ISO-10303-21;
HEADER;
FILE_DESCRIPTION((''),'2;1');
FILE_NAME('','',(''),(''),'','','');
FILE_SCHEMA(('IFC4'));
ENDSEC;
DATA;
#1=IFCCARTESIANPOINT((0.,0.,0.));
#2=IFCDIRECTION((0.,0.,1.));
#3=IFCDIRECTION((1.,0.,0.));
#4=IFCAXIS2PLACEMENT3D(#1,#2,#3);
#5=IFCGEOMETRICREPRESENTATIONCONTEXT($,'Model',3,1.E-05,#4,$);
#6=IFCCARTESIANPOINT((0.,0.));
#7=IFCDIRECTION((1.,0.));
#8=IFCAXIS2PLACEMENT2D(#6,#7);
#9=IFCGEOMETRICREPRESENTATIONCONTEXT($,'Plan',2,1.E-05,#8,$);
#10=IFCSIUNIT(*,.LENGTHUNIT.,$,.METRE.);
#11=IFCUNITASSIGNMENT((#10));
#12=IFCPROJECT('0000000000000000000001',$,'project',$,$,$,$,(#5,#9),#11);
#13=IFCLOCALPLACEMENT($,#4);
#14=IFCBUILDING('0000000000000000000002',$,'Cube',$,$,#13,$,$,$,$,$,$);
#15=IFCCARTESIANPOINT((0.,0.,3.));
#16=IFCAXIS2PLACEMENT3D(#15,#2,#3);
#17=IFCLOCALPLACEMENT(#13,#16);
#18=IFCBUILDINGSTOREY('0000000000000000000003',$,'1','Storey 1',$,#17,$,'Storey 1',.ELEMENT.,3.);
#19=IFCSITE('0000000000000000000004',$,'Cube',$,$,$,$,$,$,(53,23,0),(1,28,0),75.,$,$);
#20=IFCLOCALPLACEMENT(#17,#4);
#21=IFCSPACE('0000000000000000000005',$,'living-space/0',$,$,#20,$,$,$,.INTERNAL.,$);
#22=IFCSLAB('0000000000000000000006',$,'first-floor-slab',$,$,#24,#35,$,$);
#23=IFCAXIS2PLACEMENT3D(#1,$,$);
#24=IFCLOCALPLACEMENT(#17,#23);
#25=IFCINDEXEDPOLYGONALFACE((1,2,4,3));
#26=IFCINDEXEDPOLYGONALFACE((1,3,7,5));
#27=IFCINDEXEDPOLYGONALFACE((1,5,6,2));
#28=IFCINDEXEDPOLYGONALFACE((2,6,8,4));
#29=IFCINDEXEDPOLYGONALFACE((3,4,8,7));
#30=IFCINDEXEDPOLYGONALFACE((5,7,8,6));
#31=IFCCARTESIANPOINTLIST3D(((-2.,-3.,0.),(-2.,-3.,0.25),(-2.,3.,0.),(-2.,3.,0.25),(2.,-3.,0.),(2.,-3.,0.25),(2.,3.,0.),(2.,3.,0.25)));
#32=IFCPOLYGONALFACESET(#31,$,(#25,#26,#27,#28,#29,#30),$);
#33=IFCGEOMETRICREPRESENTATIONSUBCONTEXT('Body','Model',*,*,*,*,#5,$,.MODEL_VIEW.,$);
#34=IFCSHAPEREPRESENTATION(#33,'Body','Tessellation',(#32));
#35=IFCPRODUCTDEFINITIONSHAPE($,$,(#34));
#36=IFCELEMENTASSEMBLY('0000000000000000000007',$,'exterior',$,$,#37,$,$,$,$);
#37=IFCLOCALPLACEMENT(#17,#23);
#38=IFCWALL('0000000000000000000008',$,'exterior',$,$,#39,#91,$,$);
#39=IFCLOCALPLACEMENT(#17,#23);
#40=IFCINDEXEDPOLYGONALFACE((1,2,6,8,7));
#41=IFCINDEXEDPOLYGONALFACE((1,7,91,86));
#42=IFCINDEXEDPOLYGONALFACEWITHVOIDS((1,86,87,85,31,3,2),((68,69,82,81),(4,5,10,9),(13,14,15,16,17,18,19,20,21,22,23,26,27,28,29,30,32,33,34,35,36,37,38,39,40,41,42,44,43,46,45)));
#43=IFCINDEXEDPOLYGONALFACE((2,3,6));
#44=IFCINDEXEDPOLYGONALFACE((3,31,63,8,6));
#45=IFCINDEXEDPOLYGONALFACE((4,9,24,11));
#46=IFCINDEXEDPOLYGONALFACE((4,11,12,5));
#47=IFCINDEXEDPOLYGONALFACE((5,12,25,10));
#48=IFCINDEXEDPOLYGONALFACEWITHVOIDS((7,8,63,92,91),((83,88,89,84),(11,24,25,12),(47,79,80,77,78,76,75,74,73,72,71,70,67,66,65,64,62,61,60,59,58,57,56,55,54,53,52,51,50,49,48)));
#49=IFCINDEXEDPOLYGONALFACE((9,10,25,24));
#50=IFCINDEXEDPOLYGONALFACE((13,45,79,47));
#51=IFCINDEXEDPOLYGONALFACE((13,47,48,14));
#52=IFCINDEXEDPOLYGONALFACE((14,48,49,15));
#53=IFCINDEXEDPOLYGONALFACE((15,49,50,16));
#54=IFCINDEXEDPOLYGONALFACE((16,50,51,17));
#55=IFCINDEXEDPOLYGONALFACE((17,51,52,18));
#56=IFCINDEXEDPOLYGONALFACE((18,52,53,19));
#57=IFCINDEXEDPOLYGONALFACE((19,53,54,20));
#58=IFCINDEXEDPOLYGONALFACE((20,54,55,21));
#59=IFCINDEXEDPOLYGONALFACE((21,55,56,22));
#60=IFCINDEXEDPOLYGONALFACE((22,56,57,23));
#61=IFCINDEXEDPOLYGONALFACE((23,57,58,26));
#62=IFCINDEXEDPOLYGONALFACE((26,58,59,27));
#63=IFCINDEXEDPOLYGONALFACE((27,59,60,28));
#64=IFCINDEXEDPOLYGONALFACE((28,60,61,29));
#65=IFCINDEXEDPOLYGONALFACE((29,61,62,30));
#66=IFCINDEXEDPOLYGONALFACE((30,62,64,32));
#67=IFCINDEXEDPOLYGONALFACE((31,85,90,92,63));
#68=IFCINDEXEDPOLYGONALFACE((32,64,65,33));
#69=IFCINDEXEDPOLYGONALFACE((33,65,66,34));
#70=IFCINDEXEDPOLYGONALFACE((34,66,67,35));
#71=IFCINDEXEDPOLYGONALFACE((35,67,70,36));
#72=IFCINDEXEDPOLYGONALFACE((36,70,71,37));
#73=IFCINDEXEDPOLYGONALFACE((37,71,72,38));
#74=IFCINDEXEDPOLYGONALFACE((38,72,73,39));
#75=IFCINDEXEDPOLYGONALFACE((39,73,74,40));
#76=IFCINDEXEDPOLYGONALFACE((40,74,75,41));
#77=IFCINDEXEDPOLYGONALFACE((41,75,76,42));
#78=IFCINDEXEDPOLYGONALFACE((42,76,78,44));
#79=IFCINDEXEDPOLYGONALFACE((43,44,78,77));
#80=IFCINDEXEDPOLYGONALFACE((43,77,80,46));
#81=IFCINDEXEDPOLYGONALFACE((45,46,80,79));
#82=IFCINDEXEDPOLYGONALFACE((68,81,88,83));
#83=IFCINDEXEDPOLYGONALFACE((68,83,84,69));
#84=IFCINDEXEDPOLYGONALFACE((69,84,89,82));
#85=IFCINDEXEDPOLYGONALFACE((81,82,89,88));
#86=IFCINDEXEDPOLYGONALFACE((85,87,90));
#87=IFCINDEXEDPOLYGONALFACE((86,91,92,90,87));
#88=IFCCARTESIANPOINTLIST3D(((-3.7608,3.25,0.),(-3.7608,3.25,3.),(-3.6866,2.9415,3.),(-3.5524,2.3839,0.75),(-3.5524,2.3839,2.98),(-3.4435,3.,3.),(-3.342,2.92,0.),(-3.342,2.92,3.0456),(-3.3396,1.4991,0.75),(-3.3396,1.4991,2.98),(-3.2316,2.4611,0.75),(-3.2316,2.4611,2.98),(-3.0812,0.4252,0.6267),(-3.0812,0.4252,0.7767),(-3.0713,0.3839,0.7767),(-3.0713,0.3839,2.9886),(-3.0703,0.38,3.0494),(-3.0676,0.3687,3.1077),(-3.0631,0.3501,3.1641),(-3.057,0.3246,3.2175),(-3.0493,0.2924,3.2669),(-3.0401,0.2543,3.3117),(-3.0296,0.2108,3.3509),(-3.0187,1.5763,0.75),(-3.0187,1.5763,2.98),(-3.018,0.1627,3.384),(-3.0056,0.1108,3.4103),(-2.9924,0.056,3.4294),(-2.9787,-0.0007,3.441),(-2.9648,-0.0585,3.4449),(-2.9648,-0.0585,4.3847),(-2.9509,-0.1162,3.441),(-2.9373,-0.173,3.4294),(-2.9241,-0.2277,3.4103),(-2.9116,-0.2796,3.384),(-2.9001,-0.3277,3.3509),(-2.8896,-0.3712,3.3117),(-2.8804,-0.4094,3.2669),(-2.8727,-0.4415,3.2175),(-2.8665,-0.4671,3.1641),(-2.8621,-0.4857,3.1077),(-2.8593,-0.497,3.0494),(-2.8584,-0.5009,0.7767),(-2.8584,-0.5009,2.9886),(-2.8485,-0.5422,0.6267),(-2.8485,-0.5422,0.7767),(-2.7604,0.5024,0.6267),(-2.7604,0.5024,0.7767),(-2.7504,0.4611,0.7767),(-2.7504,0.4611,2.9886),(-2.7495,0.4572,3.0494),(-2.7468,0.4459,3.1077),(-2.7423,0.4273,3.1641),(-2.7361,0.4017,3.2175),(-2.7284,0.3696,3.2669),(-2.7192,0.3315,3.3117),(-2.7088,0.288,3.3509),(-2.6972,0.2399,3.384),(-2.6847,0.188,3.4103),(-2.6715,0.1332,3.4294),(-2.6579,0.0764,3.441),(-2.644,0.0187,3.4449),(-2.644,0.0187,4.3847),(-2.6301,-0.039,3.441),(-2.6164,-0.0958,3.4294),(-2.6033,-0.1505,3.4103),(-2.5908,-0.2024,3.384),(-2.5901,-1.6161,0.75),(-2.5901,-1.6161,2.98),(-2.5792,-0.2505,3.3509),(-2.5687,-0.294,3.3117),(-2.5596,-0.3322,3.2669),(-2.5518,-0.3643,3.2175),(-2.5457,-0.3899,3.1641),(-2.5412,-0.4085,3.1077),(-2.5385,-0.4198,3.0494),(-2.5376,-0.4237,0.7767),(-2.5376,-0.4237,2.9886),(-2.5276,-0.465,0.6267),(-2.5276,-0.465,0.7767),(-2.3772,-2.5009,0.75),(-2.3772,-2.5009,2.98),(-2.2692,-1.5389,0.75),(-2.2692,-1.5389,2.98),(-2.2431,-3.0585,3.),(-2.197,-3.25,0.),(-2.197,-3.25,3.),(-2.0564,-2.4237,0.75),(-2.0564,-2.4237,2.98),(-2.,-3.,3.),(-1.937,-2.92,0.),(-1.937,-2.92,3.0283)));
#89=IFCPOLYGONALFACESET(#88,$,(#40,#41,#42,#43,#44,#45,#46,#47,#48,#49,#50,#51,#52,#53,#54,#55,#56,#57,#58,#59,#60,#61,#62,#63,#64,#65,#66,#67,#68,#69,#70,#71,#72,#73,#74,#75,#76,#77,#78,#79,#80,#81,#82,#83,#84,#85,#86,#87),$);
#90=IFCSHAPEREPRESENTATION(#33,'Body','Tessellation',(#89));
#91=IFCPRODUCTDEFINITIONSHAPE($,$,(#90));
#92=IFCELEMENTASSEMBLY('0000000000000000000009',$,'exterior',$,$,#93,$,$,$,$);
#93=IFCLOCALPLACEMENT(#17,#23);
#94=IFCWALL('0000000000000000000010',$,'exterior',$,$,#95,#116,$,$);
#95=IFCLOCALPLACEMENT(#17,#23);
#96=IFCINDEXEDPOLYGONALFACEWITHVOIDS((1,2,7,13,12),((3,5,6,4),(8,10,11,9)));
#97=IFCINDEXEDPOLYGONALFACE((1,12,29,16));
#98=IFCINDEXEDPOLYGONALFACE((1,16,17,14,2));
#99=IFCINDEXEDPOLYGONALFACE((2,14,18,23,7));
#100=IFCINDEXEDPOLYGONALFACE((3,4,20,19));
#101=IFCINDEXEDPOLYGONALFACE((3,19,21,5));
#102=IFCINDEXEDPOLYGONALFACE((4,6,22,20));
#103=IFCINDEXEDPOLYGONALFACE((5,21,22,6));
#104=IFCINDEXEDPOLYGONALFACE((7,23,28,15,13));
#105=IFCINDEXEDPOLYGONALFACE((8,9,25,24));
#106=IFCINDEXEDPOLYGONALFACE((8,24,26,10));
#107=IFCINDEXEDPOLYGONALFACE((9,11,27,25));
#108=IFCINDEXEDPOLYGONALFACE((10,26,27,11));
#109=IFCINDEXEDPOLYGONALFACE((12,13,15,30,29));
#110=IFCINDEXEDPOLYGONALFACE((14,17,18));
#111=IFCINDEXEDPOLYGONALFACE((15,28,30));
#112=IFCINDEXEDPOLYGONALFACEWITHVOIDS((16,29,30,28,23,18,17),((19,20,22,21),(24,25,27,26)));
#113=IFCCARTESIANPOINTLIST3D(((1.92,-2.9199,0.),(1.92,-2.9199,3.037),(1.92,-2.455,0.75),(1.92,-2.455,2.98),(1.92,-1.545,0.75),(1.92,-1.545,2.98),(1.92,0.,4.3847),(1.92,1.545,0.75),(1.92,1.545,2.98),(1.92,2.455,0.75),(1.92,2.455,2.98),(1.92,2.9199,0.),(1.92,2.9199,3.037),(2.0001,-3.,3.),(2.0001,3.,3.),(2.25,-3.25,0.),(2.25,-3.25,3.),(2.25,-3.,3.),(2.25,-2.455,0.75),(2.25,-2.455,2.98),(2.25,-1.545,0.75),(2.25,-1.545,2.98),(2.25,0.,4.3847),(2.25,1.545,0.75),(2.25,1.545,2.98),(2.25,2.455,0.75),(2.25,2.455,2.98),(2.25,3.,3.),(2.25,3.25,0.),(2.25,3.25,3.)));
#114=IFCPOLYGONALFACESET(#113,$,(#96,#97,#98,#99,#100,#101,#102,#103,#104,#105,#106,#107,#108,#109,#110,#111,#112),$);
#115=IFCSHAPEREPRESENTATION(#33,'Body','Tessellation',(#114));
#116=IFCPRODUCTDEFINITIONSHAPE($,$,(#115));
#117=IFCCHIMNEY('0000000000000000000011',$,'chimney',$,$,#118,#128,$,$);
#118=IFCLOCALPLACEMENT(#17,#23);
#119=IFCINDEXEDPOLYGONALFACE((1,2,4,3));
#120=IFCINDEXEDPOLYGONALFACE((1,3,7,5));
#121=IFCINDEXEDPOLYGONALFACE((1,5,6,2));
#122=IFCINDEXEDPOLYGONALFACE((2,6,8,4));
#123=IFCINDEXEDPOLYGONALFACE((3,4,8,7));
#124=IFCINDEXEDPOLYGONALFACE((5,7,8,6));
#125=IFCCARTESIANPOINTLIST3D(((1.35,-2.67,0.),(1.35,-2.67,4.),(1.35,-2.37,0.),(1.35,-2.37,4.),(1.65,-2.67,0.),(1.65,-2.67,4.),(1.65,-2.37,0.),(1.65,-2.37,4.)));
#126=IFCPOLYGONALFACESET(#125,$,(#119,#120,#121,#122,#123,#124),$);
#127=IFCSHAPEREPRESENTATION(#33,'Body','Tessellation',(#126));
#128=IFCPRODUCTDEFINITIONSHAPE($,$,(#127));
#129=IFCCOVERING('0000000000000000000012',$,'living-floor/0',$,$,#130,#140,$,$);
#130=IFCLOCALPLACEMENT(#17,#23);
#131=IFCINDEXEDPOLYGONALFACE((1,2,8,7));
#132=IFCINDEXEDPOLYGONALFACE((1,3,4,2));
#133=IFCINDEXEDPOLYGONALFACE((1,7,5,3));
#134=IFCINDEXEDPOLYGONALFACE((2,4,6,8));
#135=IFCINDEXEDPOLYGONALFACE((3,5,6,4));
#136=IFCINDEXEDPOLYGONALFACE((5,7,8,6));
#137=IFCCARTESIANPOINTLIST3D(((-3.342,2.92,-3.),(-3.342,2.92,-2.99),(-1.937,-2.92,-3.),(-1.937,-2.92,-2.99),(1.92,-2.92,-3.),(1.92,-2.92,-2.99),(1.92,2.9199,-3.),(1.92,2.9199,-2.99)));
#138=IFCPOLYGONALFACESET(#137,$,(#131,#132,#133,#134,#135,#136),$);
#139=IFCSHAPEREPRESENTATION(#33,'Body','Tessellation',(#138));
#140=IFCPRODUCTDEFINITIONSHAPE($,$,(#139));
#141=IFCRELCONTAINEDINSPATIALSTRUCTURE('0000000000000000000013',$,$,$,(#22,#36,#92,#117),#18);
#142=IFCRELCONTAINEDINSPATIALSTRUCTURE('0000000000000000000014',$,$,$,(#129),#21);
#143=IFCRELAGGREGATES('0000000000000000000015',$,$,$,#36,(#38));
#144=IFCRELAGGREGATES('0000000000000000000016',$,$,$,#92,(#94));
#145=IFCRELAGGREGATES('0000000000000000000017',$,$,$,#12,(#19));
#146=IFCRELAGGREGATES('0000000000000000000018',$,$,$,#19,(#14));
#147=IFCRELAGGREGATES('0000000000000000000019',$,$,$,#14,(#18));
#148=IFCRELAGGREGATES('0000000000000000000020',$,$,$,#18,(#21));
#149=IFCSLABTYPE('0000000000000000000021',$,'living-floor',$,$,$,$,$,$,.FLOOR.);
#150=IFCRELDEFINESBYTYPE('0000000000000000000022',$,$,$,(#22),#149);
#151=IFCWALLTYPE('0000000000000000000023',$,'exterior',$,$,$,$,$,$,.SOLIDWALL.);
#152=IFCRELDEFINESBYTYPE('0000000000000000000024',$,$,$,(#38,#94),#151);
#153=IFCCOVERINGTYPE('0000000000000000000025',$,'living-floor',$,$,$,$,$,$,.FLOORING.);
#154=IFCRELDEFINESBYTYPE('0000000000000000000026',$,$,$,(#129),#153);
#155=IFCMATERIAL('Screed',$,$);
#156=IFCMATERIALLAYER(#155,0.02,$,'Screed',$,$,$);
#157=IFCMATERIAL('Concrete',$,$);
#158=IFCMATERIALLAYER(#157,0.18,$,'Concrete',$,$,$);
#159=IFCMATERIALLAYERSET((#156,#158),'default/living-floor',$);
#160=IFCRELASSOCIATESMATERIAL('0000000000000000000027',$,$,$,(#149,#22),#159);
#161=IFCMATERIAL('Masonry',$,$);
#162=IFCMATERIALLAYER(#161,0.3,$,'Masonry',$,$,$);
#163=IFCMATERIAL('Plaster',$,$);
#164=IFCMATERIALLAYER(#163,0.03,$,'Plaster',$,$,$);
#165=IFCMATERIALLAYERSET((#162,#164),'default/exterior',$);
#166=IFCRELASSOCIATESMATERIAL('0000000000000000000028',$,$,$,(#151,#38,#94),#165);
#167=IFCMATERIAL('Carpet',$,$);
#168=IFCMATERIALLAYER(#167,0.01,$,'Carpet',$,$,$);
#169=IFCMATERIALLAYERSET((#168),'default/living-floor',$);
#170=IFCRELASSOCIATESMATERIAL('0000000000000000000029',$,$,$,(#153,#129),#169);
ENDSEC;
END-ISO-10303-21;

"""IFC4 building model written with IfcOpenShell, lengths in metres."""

from ifc_helpers import new_model, si_unit, frame, origin, origin_with_axes, origin_2d_with_axis, place, context, subcontext, project, spatial, polyline, indexed_curve, outline, extrude, clip, bounded_halfspace, material, layer, layer_set, layer_usage, type_object, element, aggregate, save


model = new_model("IFC4")

# Units and contexts
model_context = context("Model", 3, precision=1e-05, world=origin_with_axes())
plan_context = context("Plan", 2, precision=1e-05, world=origin_2d_with_axis())
body_context_1 = subcontext(model_context, "Body", "Model", "MODEL_VIEW")
ifc_project = project(units=[si_unit("LENGTHUNIT", "METRE")], contexts=[model_context, plan_context])

# Site, building, storey
site = spatial("IfcSite", under=ifc_project, Name="Cube", RefLatitude=(53, 23, 0), RefLongitude=(1, 28, 0), RefElevation=75.0)
building_placement = place(None, origin_with_axes())
building = spatial("IfcBuilding", under=site, at=building_placement, Name="Cube")
storey_placement = place(building_placement, frame((0.0, 0.0, 3.0), z_axis=(0.0, 0.0, 1.0), x_axis=(1.0, 0.0, 0.0)))
storey = spatial("IfcBuildingStorey", under=building, at=storey_placement, Name="1", Description="Storey 1", LongName="Storey 1", CompositionType="ELEMENT", Elevation=3.0)

# Slab
ifc_material_1 = material(Name="Screed")
ifc_layer_1 = layer(ifc_material_1, 0.02, Name="Screed")
ifc_material_2 = material(Name="Concrete")
ifc_layer_2 = layer(ifc_material_2, 0.18, Name="Concrete")
ifc_layer_set_1 = layer_set([ifc_layer_1, ifc_layer_2], Name="default/living-floor")
ifc_layer_usage_1 = layer_usage(ifc_layer_set_1, "AXIS3", "POSITIVE", 0.0)
slab_type = type_object("IfcSlabType", Name="living-floor", PredefinedType="FLOOR", material=ifc_layer_set_1)
slab_placement = place(storey_placement, frame((-2.0, -3.0, 0.0), z_axis=(0.0, 0.0, 1.0), x_axis=(1.0, 0.0, 0.0)))
element("IfcSlab", 1, at=slab_placement, inside=storey, type_object=slab_type, material=ifc_layer_usage_1, Name="first-floor-slab", context=body_context_1, shape_type="SweptSolid", body=[
    extrude(outline(indexed_curve([(0.0, 0.0), (4.0, 0.0), (4.0, 6.0), (0.0, 6.0)])), None, (0.0, 0.0, 1.0), 0.25),
])

# Element assemblies, walls, openings
assembly_1_placement = place(storey_placement, frame((-3.4435, 3.0, 0.0), z_axis=(0.0, 0.0, 1.0), x_axis=(0.233915, -0.972257, 0.0)))
assembly_1 = element("IfcElementAssembly", 2, at=assembly_1_placement, inside=storey, Name="exterior")
ifc_material_3 = material(Name="Masonry")
ifc_layer_3 = layer(ifc_material_3, 0.3, Name="Masonry")
ifc_material_4 = material(Name="Plaster")
ifc_layer_4 = layer(ifc_material_4, 0.03, Name="Plaster")
ifc_layer_set_2 = layer_set([ifc_layer_3, ifc_layer_4], Name="default/exterior")
ifc_layer_usage_2 = layer_usage(ifc_layer_set_2, "AXIS2", "POSITIVE", -0.25)
wall_type = type_object("IfcWallType", Name="exterior", PredefinedType="SOLIDWALL", material=ifc_layer_set_2)
wall_1_placement = place(assembly_1_placement, frame((0.0, 0.0, 0.0), z_axis=(0.0, 0.0, 1.0), x_axis=(1.0, 0.0, 0.0)))
wall_1 = element("IfcWall", 3, at=wall_1_placement, type_object=wall_type, material=ifc_layer_usage_2, Name="exterior", context=body_context_1, shape_type="Clipping", body=[
    clip(clip(clip(clip(extrude(outline(polyline([(0.1015, 0.08), (-0.3173, -0.25), (6.3682, -0.25), (6.1082, 0.08), (0.1015, 0.08)])), origin(), (0.0, 0.0, 1.0), 4.385), bounded_halfspace(frame((6.1712, 0.0, 3.0), z_axis=(0.409415, 0.0, 0.912348), x_axis=(0.0, -1.0, 0.0)), False, origin(), polyline([(6.1712, -1.0), (3.0856, -1.0), (3.0856, 1.0), (6.1712, 1.0), (6.1712, -1.0)]))), bounded_halfspace(frame((6.1712, 0.0, 3.0), z_axis=(0.0, 0.0, 1.0), x_axis=(0.0, 1.0, 0.0)), False, origin(), polyline([(6.1712, 1.0), (7.1712, 1.0), (7.1712, -1.0), (6.1712, -1.0), (6.1712, 1.0)]))), bounded_halfspace(frame((3.0856, 0.0, 4.3847), z_axis=(-0.409415, 0.0, 0.912348), x_axis=(0.0, -1.0, 0.0)), False, origin(), polyline([(3.0856, -1.0), (0.0, -1.0), (0.0, 1.0), (3.0856, 1.0), (3.0856, -1.0)]))), bounded_halfspace(frame((0.0, 0.0, 3.0), z_axis=(0.0, 0.0, 1.0), x_axis=(0.0, -1.0, 0.0)), False, origin(), polyline([(0.0, -1.0), (-1.0, -1.0), (-1.0, 1.0), (0.0, 1.0), (0.0, -1.0)]))),
])
opening_1_placement = place(wall_1_placement, frame((0.5735, -0.25, 0.75), z_axis=(0.0, 0.0, 1.0), x_axis=(1.0, 0.0, 0.0)))
element("IfcOpeningElement", 4, at=opening_1_placement, cuts=wall_1, PredefinedType="OPENING", context=body_context_1, shape_type="SweptSolid", body=[
    extrude(outline(polyline([(0.0, -0.02), (0.91, -0.02), (0.91, 0.35), (0.0, 0.35), (0.0, -0.02)])), origin(), (0.0, 0.0, 1.0), 2.23),
])
opening_2_placement = place(wall_1_placement, frame((2.6306, -0.25, 0.75), z_axis=(0.0, 0.0, 1.0), x_axis=(1.0, 0.0, 0.0)))
element("IfcOpeningElement", 5, at=opening_2_placement, cuts=wall_1, PredefinedType="OPENING", context=body_context_1, shape_type="SweptSolid", body=[
    extrude(outline(polyline([(0.1333, 2.5617), (0.1781, 2.6009), (0.2275, 2.634), (0.2809, 2.6603), (0.3373, 2.6794), (0.3956, 2.691), (0.455, 2.6949), (0.5144, 2.691), (0.5727, 2.6794), (0.6291, 2.6603), (0.6825, 2.634), (0.7319, 2.6009), (0.7767, 2.5617), (0.8159, 2.5169), (0.849, 2.4675), (0.8753, 2.4141), (0.8944, 2.3577), (0.906, 2.2994), (0.91, 2.2386), (0.91, 2.2069), (0.91, 0.0267), (0.9525, 0.0267), (0.9525, -0.1233), (-0.0425, -0.1233), (-0.0425, 0.0267), (0.0, 0.0267), (0.0, 2.2069), (0.0, 2.2386), (0.004, 2.2994), (0.0156, 2.3577), (0.0347, 2.4141), (0.061, 2.4675), (0.0941, 2.5169), (0.1333, 2.5617)])), frame((0.0, -0.02, 0.0), z_axis=(0.0, -1.0, 0.0), x_axis=(1.0, 0.0, 0.0)), (0.0, 0.0, -1.0), 0.37),
])
opening_3_placement = place(wall_1_placement, frame((4.6877, -0.25, 0.75), z_axis=(0.0, 0.0, 1.0), x_axis=(1.0, 0.0, 0.0)))
element("IfcOpeningElement", 6, at=opening_3_placement, cuts=wall_1, PredefinedType="OPENING", context=body_context_1, shape_type="SweptSolid", body=[
    extrude(outline(polyline([(0.0, -0.02), (0.91, -0.02), (0.91, 0.35), (0.0, 0.35), (0.0, -0.02)])), origin(), (0.0, 0.0, 1.0), 2.23),
])
aggregate(assembly_1, [wall_1])
assembly_2_placement = place(storey_placement, frame((2.0, -3.0, 0.0), z_axis=(0.0, 0.0, 1.0), x_axis=(0.0, 1.0, 0.0)))
assembly_2 = element("IfcElementAssembly", 7, at=assembly_2_placement, inside=storey, Name="exterior")
ifc_layer_usage_3 = layer_usage(ifc_layer_set_2, "AXIS2", "POSITIVE", -0.25)
wall_2_placement = place(assembly_2_placement, origin_with_axes())
wall_2 = element("IfcWall", 8, at=wall_2_placement, type_object=wall_type, material=ifc_layer_usage_3, Name="exterior", context=body_context_1, shape_type="Clipping", body=[
    clip(clip(clip(clip(extrude(outline(polyline([(0.0801, 0.08), (-0.25, -0.25), (6.25, -0.25), (5.9199, 0.08), (0.0801, 0.08)])), origin(), (0.0, 0.0, 1.0), 4.385), bounded_halfspace(frame((6.0, 0.0, 3.0), z_axis=(0.419069, 0.0, 0.907954), x_axis=(0.0, -1.0, 0.0)), False, origin(), polyline([(6.0, -1.0), (3.0, -1.0), (3.0, 1.0), (6.0, 1.0), (6.0, -1.0)]))), bounded_halfspace(frame((6.0, 0.0, 3.0), z_axis=(0.0, 0.0, 1.0), x_axis=(0.0, 1.0, 0.0)), False, origin(), polyline([(6.0, 1.0), (7.0, 1.0), (7.0, -1.0), (6.0, -1.0), (6.0, 1.0)]))), bounded_halfspace(frame((3.0, 0.0, 4.3847), z_axis=(-0.419069, 0.0, 0.907954), x_axis=(0.0, -1.0, 0.0)), False, origin(), polyline([(3.0, -1.0), (0.0, -1.0), (0.0, 1.0), (3.0, 1.0), (3.0, -1.0)]))), bounded_halfspace(frame((0.0, 0.0, 3.0), z_axis=(0.0, 0.0, 1.0), x_axis=(0.0, -1.0, 0.0)), False, origin(), polyline([(0.0, -1.0), (-1.0, -1.0), (-1.0, 1.0), (0.0, 1.0), (0.0, -1.0)]))),
])
opening_4_placement = place(wall_2_placement, frame((0.545, -0.25, 0.75), z_axis=(0.0, 0.0, 1.0), x_axis=(1.0, 0.0, 0.0)))
element("IfcOpeningElement", 9, at=opening_4_placement, cuts=wall_2, PredefinedType="OPENING", context=body_context_1, shape_type="SweptSolid", body=[
    extrude(outline(polyline([(0.0, -0.02), (0.91, -0.02), (0.91, 0.35), (0.0, 0.35), (0.0, -0.02)])), origin(), (0.0, 0.0, 1.0), 2.23),
])
opening_5_placement = place(wall_2_placement, frame((4.545, -0.25, 0.75), z_axis=(0.0, 0.0, 1.0), x_axis=(1.0, 0.0, 0.0)))
element("IfcOpeningElement", 10, at=opening_5_placement, cuts=wall_2, PredefinedType="OPENING", context=body_context_1, shape_type="SweptSolid", body=[
    extrude(outline(polyline([(0.0, -0.02), (0.91, -0.02), (0.91, 0.35), (0.0, 0.35), (0.0, -0.02)])), origin(), (0.0, 0.0, 1.0), 2.23),
])
aggregate(assembly_2, [wall_2])

# Chimney
chimney_placement = place(storey_placement, frame((1.35, -2.67, 0.0), z_axis=(0.0, 0.0, 1.0), x_axis=(1.0, 0.0, 0.0)))
element("IfcChimney", 11, at=chimney_placement, inside=storey, Name="chimney", context=body_context_1, shape_type="SweptSolid", body=[
    extrude(outline(indexed_curve([(0.0, 0.0), (0.3, 0.0), (0.3, 0.3), (0.0, 0.3)])), None, (0.0, 0.0, 1.0), 4.0),
])

# Shared definitions
space_placement = place(storey_placement, origin_with_axes())
space = spatial("IfcSpace", under=storey, at=space_placement, Name="living-space/0", PredefinedType="INTERNAL")

# Covering
ifc_material_5 = material(Name="Carpet")
ifc_layer_5 = layer(ifc_material_5, 0.01, Name="Carpet")
ifc_layer_set_3 = layer_set([ifc_layer_5], Name="default/living-floor")
ifc_layer_usage_4 = layer_usage(ifc_layer_set_3, "AXIS3", "POSITIVE", 0.0)
covering_type = type_object("IfcCoveringType", Name="living-floor", PredefinedType="FLOORING", material=ifc_layer_set_3)
covering_placement = place(space_placement, frame((0.0, 0.0, -3.0), z_axis=(0.0, 0.0, 1.0), x_axis=(1.0, 0.0, 0.0)))
element("IfcCovering", 12, at=covering_placement, inside=space, type_object=covering_type, material=ifc_layer_usage_4, Name="living-floor/0", context=body_context_1, shape_type="SweptSolid", body=[
    extrude(outline(polyline([(1.92, 2.9199), (-3.342, 2.92), (-1.937, -2.92), (1.92, -2.92), (1.92, 2.9199)])), origin_with_axes(), (0.0, 0.0, 1.0), 0.01),
])

save(model, "model.ifc")
